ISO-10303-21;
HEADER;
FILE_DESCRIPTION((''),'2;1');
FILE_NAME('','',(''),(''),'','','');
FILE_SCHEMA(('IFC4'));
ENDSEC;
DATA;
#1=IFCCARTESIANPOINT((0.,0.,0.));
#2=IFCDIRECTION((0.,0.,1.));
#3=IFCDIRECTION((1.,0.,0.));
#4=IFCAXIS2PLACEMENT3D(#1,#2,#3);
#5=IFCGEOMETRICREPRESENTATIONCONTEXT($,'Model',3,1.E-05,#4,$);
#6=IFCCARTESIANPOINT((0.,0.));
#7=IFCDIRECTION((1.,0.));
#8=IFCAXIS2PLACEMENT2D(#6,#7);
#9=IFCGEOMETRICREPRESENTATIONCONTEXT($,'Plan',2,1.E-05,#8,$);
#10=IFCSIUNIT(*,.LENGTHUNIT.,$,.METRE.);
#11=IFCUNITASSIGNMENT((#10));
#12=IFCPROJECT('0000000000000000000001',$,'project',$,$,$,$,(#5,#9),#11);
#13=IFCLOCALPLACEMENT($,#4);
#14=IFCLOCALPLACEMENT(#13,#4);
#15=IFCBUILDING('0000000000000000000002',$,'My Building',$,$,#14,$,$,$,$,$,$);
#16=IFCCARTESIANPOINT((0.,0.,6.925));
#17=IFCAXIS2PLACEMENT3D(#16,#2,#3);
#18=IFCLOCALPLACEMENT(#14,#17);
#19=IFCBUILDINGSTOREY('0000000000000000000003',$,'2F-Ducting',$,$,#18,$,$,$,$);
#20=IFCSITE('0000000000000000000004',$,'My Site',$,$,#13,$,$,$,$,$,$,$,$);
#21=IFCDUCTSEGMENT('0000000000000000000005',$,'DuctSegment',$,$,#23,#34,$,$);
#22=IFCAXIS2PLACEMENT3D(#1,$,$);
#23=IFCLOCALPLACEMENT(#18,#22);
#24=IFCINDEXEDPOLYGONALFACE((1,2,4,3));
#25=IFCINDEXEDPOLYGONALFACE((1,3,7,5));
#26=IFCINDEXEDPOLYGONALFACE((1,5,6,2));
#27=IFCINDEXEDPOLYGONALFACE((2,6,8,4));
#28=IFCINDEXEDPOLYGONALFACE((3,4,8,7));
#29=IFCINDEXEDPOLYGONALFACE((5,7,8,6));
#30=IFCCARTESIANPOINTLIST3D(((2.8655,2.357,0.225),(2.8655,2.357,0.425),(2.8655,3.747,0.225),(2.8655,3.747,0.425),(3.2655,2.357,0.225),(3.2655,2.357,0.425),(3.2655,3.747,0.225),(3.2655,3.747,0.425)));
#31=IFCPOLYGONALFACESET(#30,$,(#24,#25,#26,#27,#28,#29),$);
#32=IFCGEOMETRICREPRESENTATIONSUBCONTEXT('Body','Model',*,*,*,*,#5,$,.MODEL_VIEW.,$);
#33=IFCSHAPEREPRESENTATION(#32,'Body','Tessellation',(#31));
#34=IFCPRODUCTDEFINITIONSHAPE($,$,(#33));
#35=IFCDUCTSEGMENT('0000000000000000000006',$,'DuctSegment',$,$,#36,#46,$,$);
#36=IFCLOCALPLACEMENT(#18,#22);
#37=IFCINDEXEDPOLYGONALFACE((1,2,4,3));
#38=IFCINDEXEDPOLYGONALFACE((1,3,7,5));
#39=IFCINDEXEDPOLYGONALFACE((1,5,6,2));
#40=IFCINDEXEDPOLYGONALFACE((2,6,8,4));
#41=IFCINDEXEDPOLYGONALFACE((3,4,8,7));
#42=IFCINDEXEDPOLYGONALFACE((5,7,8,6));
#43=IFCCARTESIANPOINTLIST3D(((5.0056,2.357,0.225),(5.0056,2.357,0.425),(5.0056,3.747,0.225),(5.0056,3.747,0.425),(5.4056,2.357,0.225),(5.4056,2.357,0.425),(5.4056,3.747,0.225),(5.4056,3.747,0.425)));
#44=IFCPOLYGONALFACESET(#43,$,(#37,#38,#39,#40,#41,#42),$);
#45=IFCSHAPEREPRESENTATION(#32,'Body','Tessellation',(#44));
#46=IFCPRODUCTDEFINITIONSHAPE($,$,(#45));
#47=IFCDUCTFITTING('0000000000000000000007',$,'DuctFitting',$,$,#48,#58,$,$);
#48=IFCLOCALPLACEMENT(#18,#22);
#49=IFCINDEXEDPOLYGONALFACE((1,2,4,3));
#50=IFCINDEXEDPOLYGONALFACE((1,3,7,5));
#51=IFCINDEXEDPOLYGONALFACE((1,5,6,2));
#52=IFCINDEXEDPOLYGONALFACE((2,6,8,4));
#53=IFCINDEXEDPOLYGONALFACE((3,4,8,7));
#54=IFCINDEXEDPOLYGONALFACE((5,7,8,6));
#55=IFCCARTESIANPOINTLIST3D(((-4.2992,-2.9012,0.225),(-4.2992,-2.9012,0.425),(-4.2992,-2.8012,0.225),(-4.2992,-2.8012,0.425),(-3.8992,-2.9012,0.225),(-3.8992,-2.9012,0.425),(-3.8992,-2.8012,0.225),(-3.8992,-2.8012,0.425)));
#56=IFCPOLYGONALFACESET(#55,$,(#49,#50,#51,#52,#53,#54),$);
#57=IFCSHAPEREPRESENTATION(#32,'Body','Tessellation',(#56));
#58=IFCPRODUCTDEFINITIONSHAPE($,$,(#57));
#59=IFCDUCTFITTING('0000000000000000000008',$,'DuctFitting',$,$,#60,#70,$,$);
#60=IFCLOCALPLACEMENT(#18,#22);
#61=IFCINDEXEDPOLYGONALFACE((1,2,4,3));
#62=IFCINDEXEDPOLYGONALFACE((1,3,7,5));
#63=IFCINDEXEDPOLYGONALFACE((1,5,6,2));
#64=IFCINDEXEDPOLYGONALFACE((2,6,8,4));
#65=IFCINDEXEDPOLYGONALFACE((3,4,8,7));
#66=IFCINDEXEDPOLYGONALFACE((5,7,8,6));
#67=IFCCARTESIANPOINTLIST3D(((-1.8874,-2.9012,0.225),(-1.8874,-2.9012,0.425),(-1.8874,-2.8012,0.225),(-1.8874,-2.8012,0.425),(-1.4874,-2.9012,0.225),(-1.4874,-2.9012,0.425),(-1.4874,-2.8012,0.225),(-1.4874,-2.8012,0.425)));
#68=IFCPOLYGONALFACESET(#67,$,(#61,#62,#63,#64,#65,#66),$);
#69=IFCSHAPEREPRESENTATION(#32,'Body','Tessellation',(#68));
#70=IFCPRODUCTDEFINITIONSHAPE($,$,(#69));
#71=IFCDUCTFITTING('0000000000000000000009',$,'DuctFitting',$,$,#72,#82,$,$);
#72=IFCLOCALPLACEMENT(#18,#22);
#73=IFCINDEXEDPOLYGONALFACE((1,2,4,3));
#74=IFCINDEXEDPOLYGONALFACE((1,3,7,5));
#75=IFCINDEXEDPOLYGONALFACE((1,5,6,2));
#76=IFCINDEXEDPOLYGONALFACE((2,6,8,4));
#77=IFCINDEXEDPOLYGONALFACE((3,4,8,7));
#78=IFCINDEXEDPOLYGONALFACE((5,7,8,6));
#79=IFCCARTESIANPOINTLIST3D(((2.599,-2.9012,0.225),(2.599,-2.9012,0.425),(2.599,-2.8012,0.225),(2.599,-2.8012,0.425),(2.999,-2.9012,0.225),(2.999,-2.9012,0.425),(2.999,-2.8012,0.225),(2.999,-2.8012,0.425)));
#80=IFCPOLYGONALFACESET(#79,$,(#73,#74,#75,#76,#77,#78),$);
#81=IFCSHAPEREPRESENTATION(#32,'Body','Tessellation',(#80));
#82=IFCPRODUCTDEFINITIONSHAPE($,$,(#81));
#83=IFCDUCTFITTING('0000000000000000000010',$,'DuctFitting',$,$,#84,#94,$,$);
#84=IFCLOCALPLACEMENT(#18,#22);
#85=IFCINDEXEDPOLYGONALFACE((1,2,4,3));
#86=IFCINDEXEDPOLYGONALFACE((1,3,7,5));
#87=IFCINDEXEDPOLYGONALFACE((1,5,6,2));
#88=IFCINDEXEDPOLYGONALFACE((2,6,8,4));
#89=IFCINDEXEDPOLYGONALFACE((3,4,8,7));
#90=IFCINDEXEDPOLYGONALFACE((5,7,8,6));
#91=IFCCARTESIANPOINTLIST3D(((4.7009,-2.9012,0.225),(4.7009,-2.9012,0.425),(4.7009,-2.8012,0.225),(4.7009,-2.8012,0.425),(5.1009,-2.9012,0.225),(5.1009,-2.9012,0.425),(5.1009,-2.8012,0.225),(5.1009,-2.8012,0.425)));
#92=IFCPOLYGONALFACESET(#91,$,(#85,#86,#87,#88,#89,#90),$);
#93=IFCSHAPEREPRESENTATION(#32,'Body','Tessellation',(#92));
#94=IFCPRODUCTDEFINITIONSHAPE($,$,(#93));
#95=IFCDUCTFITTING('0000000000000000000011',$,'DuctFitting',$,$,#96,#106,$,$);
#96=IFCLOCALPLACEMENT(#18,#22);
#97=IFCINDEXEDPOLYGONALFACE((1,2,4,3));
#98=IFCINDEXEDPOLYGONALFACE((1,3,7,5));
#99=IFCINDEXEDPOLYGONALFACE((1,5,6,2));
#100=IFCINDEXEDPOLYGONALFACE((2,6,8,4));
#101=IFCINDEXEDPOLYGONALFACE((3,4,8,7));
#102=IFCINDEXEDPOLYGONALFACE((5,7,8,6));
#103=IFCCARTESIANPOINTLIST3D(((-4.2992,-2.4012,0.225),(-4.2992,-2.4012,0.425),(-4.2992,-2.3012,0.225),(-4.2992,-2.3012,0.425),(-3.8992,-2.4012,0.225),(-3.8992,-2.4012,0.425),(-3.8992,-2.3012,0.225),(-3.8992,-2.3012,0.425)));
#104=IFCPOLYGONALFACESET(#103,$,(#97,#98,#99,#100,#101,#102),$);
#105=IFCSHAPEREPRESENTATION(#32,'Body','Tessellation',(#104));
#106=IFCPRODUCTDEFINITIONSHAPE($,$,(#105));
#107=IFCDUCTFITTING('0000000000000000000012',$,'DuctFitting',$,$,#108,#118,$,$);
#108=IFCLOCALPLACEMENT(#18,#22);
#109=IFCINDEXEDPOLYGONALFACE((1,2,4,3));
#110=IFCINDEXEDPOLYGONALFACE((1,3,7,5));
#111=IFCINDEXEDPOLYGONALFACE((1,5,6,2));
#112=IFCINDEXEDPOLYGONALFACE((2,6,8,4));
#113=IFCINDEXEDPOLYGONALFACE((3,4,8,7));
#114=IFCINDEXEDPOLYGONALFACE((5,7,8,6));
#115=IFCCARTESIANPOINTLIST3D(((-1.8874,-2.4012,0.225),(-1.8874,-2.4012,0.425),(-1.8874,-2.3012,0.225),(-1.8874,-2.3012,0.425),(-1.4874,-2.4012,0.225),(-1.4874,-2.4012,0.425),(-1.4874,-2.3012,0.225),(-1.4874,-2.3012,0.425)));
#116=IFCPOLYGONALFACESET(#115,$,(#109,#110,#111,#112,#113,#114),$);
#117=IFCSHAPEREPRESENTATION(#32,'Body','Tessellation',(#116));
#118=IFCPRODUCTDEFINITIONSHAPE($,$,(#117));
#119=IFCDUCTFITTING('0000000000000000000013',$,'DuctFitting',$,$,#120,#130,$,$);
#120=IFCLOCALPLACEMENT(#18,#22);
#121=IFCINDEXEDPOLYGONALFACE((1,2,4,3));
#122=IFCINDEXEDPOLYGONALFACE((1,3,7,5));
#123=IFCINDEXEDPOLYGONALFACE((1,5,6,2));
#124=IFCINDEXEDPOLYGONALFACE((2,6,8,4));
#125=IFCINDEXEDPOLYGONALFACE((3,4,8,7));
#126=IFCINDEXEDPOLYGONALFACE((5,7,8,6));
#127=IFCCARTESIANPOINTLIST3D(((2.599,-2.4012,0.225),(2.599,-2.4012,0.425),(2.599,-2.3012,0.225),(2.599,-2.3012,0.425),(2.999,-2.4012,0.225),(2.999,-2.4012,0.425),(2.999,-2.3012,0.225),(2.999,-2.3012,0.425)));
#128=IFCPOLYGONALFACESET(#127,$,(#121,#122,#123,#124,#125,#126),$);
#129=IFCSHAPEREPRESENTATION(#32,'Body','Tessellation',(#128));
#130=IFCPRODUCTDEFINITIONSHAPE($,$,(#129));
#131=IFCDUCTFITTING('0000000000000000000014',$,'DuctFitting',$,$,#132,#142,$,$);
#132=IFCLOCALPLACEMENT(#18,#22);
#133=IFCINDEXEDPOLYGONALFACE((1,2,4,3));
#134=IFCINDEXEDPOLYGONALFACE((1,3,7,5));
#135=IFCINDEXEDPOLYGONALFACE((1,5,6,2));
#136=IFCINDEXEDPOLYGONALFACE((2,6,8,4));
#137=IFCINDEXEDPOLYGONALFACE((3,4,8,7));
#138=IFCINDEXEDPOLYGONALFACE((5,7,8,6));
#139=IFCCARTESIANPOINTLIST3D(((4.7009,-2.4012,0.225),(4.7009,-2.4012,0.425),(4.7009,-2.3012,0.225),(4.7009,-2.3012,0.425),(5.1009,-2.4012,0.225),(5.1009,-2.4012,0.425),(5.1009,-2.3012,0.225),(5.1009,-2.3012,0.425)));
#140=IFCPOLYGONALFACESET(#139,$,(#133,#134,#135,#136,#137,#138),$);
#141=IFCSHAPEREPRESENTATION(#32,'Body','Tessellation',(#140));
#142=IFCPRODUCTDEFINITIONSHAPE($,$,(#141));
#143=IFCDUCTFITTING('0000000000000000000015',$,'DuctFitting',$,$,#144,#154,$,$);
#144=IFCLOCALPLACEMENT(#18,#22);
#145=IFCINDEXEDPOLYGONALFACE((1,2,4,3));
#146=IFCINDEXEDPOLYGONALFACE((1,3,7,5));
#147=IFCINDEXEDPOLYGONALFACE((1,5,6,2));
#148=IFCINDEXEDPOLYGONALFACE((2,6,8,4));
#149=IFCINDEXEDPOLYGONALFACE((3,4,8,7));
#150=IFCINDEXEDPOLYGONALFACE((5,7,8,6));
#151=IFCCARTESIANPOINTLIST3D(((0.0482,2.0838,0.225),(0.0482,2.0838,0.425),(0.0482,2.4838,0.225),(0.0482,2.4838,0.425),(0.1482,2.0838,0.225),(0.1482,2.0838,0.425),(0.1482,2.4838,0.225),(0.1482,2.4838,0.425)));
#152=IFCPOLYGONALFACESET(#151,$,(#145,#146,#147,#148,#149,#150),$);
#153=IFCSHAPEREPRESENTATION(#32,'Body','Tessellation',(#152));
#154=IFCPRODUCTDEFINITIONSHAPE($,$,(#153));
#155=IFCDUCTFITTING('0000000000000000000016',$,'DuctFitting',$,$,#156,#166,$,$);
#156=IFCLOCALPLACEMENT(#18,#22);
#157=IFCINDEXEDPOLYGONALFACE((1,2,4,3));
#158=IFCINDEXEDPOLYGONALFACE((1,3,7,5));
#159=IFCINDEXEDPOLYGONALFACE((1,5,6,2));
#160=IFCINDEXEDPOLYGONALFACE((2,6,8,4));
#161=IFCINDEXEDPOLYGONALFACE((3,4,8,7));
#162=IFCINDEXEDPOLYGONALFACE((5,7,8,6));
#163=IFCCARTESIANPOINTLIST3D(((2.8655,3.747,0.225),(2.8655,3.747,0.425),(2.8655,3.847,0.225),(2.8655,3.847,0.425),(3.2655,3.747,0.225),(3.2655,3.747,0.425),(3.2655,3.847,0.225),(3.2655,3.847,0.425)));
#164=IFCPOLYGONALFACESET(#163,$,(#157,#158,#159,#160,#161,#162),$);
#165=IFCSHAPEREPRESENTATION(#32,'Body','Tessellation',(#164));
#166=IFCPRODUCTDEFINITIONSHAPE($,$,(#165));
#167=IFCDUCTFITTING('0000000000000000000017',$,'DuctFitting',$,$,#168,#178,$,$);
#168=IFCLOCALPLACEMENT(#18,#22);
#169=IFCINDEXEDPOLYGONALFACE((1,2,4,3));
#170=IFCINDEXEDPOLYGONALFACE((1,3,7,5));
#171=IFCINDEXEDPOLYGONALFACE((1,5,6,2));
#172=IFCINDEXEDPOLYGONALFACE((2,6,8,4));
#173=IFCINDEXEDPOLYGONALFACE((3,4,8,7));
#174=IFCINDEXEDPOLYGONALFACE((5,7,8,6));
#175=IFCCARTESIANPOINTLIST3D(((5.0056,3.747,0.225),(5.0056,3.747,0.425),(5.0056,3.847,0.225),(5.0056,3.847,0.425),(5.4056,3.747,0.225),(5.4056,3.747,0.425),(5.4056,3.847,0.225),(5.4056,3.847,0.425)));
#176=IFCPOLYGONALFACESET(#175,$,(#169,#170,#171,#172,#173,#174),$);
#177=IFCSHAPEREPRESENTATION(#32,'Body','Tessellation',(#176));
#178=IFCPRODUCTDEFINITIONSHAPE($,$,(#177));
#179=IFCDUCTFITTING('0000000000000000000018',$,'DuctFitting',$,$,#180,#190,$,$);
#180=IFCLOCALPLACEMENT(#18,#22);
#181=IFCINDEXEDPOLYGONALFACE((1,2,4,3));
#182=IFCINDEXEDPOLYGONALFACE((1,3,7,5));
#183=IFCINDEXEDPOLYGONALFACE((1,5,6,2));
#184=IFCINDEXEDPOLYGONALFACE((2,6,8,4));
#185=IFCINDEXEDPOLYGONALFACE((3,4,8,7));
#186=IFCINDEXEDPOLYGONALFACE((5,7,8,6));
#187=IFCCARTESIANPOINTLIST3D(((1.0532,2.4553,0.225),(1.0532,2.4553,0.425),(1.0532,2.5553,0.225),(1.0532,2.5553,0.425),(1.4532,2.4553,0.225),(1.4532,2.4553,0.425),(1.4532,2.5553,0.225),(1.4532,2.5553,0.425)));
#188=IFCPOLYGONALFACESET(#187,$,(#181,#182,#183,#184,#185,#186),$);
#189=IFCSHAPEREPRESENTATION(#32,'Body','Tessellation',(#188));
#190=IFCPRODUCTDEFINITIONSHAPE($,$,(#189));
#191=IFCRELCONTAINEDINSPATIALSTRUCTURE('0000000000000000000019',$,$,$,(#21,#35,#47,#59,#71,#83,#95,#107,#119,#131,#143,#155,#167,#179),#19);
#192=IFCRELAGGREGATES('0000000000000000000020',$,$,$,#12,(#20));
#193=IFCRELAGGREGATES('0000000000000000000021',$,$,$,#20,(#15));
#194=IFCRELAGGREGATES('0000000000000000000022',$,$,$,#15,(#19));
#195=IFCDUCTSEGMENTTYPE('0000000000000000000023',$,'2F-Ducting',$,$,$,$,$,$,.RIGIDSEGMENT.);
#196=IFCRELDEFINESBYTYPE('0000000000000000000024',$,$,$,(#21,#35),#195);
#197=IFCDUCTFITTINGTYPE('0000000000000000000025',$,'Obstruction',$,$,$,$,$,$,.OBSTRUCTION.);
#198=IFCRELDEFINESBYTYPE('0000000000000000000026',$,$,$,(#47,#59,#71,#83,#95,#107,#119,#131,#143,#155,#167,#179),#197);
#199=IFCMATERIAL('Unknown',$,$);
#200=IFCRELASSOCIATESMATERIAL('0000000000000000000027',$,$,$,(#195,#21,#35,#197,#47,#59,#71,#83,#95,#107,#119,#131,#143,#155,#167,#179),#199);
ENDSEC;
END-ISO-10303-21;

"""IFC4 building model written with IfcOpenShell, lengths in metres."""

from ifc_helpers import new_model, si_unit, frame, origin_with_axes, origin_2d_with_axis, place, context, subcontext, project, spatial, rectangle, extrude, material, material_profile, profile_set, profile_usage, type_object, element, save


model = new_model("IFC4")

# Units and contexts
model_context = context("Model", 3, precision=1e-05, world=origin_with_axes())
plan_context = context("Plan", 2, precision=1e-05, world=origin_2d_with_axis())
body_context = subcontext(model_context, "Body", "Model", "MODEL_VIEW")
ifc_project = project(units=[si_unit("LENGTHUNIT", "METRE")], contexts=[model_context, plan_context])

# Site, building, storey
site_placement = place(None, origin_with_axes())
site = spatial("IfcSite", under=ifc_project, at=site_placement, Name="My Site")
building_placement = place(site_placement, origin_with_axes())
building = spatial("IfcBuilding", under=site, at=building_placement, Name="My Building")
storey_placement = place(building_placement, frame((0.0, 0.0, 6.925), z_axis=(0.0, 0.0, 1.0), x_axis=(1.0, 0.0, 0.0)))
storey = spatial("IfcBuildingStorey", under=building, at=storey_placement, Name="2F-Ducting")

# Duct segments
ifc_material = material(Name="Unknown")
ifc_material_profile_1 = material_profile(ifc_material, rectangle(XDim=0.4, YDim=0.2))
ifc_profile_set_1 = profile_set([ifc_material_profile_1])
duct_segment_type = type_object("IfcDuctSegmentType", Name="2F-Ducting", PredefinedType="RIGIDSEGMENT", material=ifc_profile_set_1)
ifc_profile_usage_1 = profile_usage(ifc_profile_set_1, cardinal=5)
duct_segment_1_placement = place(storey_placement, frame((3.0655, 3.747, 0.325), z_axis=(0.0, -1.0, 0.0), x_axis=(1.0, 0.0, 0.0)))
element("IfcDuctSegment", 1, at=duct_segment_1_placement, inside=storey, type_object=duct_segment_type, material=ifc_profile_usage_1, Name="DuctSegment", context=body_context, shape_type="SweptSolid", body=[
    extrude(rectangle(XDim=0.4, YDim=0.2), origin_with_axes(), (0.0, 0.0, 1.0), 1.39),
])
ifc_profile_usage_2 = profile_usage(ifc_profile_set_1, cardinal=5)
duct_segment_2_placement = place(storey_placement, frame((5.2056, 3.747, 0.325), z_axis=(0.0, -1.0, 0.0), x_axis=(1.0, 0.0, 0.0)))
element("IfcDuctSegment", 2, at=duct_segment_2_placement, inside=storey, type_object=duct_segment_type, material=ifc_profile_usage_2, Name="DuctSegment", context=body_context, shape_type="SweptSolid", body=[
    extrude(rectangle(XDim=0.4, YDim=0.2), origin_with_axes(), (0.0, 0.0, 1.0), 1.39),
])

# Duct fittings
ifc_material_profile_2 = material_profile(ifc_material, rectangle(XDim=0.4, YDim=0.2))
ifc_profile_set_2 = profile_set([ifc_material_profile_2])
ifc_profile_usage_3 = profile_usage(ifc_profile_set_2, cardinal=5)
duct_fitting_type = type_object("IfcDuctFittingType", Name="Obstruction", PredefinedType="OBSTRUCTION", material=ifc_profile_set_2)
duct_fitting_1_placement = place(storey_placement, frame((-4.0992, -2.9012, 0.325), z_axis=(0.0, 1.0, 0.0), x_axis=(-1.0, 0.0, 0.0)))
element("IfcDuctFitting", 3, at=duct_fitting_1_placement, inside=storey, type_object=duct_fitting_type, material=ifc_profile_usage_3, Name="DuctFitting", context=body_context, shape_type="SweptSolid", body=[
    extrude(rectangle(XDim=0.4, YDim=0.2), origin_with_axes(), (0.0, 0.0, 1.0), 0.1),
])
ifc_profile_usage_4 = profile_usage(ifc_profile_set_2, cardinal=5)
duct_fitting_2_placement = place(storey_placement, frame((-1.6874, -2.9012, 0.325), z_axis=(0.0, 1.0, 0.0), x_axis=(-1.0, 0.0, 0.0)))
element("IfcDuctFitting", 4, at=duct_fitting_2_placement, inside=storey, type_object=duct_fitting_type, material=ifc_profile_usage_4, Name="DuctFitting", context=body_context, shape_type="SweptSolid", body=[
    extrude(rectangle(XDim=0.4, YDim=0.2), origin_with_axes(), (0.0, 0.0, 1.0), 0.1),
])
ifc_profile_usage_5 = profile_usage(ifc_profile_set_2, cardinal=5)
duct_fitting_3_placement = place(storey_placement, frame((2.799, -2.9012, 0.325), z_axis=(0.0, 1.0, 0.0), x_axis=(-1.0, 0.0, 0.0)))
element("IfcDuctFitting", 5, at=duct_fitting_3_placement, inside=storey, type_object=duct_fitting_type, material=ifc_profile_usage_5, Name="DuctFitting", context=body_context, shape_type="SweptSolid", body=[
    extrude(rectangle(XDim=0.4, YDim=0.2), origin_with_axes(), (0.0, 0.0, 1.0), 0.1),
])
ifc_profile_usage_6 = profile_usage(ifc_profile_set_2, cardinal=5)
duct_fitting_4_placement = place(storey_placement, frame((4.9009, -2.9012, 0.325), z_axis=(0.0, 1.0, 0.0), x_axis=(-1.0, 0.0, 0.0)))
element("IfcDuctFitting", 6, at=duct_fitting_4_placement, inside=storey, type_object=duct_fitting_type, material=ifc_profile_usage_6, Name="DuctFitting", context=body_context, shape_type="SweptSolid", body=[
    extrude(rectangle(XDim=0.4, YDim=0.2), origin_with_axes(), (0.0, 0.0, 1.0), 0.1),
])
ifc_profile_usage_7 = profile_usage(ifc_profile_set_2, cardinal=5)
duct_fitting_5_placement = place(storey_placement, frame((-4.0992, -2.4012, 0.325), z_axis=(0.0, 1.0, 0.0), x_axis=(-1.0, 0.0, 0.0)))
element("IfcDuctFitting", 7, at=duct_fitting_5_placement, inside=storey, type_object=duct_fitting_type, material=ifc_profile_usage_7, Name="DuctFitting", context=body_context, shape_type="SweptSolid", body=[
    extrude(rectangle(XDim=0.4, YDim=0.2), origin_with_axes(), (0.0, 0.0, 1.0), 0.1),
])
ifc_profile_usage_8 = profile_usage(ifc_profile_set_2, cardinal=5)
duct_fitting_6_placement = place(storey_placement, frame((-1.6874, -2.4012, 0.325), z_axis=(0.0, 1.0, 0.0), x_axis=(-1.0, 0.0, 0.0)))
element("IfcDuctFitting", 8, at=duct_fitting_6_placement, inside=storey, type_object=duct_fitting_type, material=ifc_profile_usage_8, Name="DuctFitting", context=body_context, shape_type="SweptSolid", body=[
    extrude(rectangle(XDim=0.4, YDim=0.2), origin_with_axes(), (0.0, 0.0, 1.0), 0.1),
])
ifc_profile_usage_9 = profile_usage(ifc_profile_set_2, cardinal=5)
duct_fitting_7_placement = place(storey_placement, frame((2.799, -2.4012, 0.325), z_axis=(0.0, 1.0, 0.0), x_axis=(-1.0, 0.0, 0.0)))
element("IfcDuctFitting", 9, at=duct_fitting_7_placement, inside=storey, type_object=duct_fitting_type, material=ifc_profile_usage_9, Name="DuctFitting", context=body_context, shape_type="SweptSolid", body=[
    extrude(rectangle(XDim=0.4, YDim=0.2), origin_with_axes(), (0.0, 0.0, 1.0), 0.1),
])
ifc_profile_usage_10 = profile_usage(ifc_profile_set_2, cardinal=5)
duct_fitting_8_placement = place(storey_placement, frame((4.9009, -2.4012, 0.325), z_axis=(0.0, 1.0, 0.0), x_axis=(-1.0, 0.0, 0.0)))
element("IfcDuctFitting", 10, at=duct_fitting_8_placement, inside=storey, type_object=duct_fitting_type, material=ifc_profile_usage_10, Name="DuctFitting", context=body_context, shape_type="SweptSolid", body=[
    extrude(rectangle(XDim=0.4, YDim=0.2), origin_with_axes(), (0.0, 0.0, 1.0), 0.1),
])
ifc_profile_usage_11 = profile_usage(ifc_profile_set_2, cardinal=5)
duct_fitting_9_placement = place(storey_placement, frame((0.1482, 2.2838, 0.325), z_axis=(-1.0, 0.0, 0.0), x_axis=(0.0, -1.0, 0.0)))
element("IfcDuctFitting", 11, at=duct_fitting_9_placement, inside=storey, type_object=duct_fitting_type, material=ifc_profile_usage_11, Name="DuctFitting", context=body_context, shape_type="SweptSolid", body=[
    extrude(rectangle(XDim=0.4, YDim=0.2), origin_with_axes(), (0.0, 0.0, 1.0), 0.1),
])
ifc_profile_usage_12 = profile_usage(ifc_profile_set_2, cardinal=5)
duct_fitting_10_placement = place(storey_placement, frame((3.0655, 3.847, 0.325), z_axis=(0.0, -1.0, 0.0), x_axis=(1.0, 0.0, 0.0)))
element("IfcDuctFitting", 12, at=duct_fitting_10_placement, inside=storey, type_object=duct_fitting_type, material=ifc_profile_usage_12, Name="DuctFitting", context=body_context, shape_type="SweptSolid", body=[
    extrude(rectangle(XDim=0.4, YDim=0.2), origin_with_axes(), (0.0, 0.0, 1.0), 0.1),
])
ifc_profile_usage_13 = profile_usage(ifc_profile_set_2, cardinal=5)
duct_fitting_11_placement = place(storey_placement, frame((5.2056, 3.847, 0.325), z_axis=(0.0, -1.0, 0.0), x_axis=(1.0, 0.0, 0.0)))
element("IfcDuctFitting", 13, at=duct_fitting_11_placement, inside=storey, type_object=duct_fitting_type, material=ifc_profile_usage_13, Name="DuctFitting", context=body_context, shape_type="SweptSolid", body=[
    extrude(rectangle(XDim=0.4, YDim=0.2), origin_with_axes(), (0.0, 0.0, 1.0), 0.1),
])
ifc_profile_usage_14 = profile_usage(ifc_profile_set_2, cardinal=5)
duct_fitting_12_placement = place(storey_placement, frame((1.2532, 2.5553, 0.325), z_axis=(0.0, -1.0, 0.0), x_axis=(1.0, 0.0, 0.0)))
element("IfcDuctFitting", 14, at=duct_fitting_12_placement, inside=storey, type_object=duct_fitting_type, material=ifc_profile_usage_14, Name="DuctFitting", context=body_context, shape_type="SweptSolid", body=[
    extrude(rectangle(XDim=0.4, YDim=0.2), origin_with_axes(), (0.0, 0.0, 1.0), 0.1),
])

save(model, "model.ifc")
